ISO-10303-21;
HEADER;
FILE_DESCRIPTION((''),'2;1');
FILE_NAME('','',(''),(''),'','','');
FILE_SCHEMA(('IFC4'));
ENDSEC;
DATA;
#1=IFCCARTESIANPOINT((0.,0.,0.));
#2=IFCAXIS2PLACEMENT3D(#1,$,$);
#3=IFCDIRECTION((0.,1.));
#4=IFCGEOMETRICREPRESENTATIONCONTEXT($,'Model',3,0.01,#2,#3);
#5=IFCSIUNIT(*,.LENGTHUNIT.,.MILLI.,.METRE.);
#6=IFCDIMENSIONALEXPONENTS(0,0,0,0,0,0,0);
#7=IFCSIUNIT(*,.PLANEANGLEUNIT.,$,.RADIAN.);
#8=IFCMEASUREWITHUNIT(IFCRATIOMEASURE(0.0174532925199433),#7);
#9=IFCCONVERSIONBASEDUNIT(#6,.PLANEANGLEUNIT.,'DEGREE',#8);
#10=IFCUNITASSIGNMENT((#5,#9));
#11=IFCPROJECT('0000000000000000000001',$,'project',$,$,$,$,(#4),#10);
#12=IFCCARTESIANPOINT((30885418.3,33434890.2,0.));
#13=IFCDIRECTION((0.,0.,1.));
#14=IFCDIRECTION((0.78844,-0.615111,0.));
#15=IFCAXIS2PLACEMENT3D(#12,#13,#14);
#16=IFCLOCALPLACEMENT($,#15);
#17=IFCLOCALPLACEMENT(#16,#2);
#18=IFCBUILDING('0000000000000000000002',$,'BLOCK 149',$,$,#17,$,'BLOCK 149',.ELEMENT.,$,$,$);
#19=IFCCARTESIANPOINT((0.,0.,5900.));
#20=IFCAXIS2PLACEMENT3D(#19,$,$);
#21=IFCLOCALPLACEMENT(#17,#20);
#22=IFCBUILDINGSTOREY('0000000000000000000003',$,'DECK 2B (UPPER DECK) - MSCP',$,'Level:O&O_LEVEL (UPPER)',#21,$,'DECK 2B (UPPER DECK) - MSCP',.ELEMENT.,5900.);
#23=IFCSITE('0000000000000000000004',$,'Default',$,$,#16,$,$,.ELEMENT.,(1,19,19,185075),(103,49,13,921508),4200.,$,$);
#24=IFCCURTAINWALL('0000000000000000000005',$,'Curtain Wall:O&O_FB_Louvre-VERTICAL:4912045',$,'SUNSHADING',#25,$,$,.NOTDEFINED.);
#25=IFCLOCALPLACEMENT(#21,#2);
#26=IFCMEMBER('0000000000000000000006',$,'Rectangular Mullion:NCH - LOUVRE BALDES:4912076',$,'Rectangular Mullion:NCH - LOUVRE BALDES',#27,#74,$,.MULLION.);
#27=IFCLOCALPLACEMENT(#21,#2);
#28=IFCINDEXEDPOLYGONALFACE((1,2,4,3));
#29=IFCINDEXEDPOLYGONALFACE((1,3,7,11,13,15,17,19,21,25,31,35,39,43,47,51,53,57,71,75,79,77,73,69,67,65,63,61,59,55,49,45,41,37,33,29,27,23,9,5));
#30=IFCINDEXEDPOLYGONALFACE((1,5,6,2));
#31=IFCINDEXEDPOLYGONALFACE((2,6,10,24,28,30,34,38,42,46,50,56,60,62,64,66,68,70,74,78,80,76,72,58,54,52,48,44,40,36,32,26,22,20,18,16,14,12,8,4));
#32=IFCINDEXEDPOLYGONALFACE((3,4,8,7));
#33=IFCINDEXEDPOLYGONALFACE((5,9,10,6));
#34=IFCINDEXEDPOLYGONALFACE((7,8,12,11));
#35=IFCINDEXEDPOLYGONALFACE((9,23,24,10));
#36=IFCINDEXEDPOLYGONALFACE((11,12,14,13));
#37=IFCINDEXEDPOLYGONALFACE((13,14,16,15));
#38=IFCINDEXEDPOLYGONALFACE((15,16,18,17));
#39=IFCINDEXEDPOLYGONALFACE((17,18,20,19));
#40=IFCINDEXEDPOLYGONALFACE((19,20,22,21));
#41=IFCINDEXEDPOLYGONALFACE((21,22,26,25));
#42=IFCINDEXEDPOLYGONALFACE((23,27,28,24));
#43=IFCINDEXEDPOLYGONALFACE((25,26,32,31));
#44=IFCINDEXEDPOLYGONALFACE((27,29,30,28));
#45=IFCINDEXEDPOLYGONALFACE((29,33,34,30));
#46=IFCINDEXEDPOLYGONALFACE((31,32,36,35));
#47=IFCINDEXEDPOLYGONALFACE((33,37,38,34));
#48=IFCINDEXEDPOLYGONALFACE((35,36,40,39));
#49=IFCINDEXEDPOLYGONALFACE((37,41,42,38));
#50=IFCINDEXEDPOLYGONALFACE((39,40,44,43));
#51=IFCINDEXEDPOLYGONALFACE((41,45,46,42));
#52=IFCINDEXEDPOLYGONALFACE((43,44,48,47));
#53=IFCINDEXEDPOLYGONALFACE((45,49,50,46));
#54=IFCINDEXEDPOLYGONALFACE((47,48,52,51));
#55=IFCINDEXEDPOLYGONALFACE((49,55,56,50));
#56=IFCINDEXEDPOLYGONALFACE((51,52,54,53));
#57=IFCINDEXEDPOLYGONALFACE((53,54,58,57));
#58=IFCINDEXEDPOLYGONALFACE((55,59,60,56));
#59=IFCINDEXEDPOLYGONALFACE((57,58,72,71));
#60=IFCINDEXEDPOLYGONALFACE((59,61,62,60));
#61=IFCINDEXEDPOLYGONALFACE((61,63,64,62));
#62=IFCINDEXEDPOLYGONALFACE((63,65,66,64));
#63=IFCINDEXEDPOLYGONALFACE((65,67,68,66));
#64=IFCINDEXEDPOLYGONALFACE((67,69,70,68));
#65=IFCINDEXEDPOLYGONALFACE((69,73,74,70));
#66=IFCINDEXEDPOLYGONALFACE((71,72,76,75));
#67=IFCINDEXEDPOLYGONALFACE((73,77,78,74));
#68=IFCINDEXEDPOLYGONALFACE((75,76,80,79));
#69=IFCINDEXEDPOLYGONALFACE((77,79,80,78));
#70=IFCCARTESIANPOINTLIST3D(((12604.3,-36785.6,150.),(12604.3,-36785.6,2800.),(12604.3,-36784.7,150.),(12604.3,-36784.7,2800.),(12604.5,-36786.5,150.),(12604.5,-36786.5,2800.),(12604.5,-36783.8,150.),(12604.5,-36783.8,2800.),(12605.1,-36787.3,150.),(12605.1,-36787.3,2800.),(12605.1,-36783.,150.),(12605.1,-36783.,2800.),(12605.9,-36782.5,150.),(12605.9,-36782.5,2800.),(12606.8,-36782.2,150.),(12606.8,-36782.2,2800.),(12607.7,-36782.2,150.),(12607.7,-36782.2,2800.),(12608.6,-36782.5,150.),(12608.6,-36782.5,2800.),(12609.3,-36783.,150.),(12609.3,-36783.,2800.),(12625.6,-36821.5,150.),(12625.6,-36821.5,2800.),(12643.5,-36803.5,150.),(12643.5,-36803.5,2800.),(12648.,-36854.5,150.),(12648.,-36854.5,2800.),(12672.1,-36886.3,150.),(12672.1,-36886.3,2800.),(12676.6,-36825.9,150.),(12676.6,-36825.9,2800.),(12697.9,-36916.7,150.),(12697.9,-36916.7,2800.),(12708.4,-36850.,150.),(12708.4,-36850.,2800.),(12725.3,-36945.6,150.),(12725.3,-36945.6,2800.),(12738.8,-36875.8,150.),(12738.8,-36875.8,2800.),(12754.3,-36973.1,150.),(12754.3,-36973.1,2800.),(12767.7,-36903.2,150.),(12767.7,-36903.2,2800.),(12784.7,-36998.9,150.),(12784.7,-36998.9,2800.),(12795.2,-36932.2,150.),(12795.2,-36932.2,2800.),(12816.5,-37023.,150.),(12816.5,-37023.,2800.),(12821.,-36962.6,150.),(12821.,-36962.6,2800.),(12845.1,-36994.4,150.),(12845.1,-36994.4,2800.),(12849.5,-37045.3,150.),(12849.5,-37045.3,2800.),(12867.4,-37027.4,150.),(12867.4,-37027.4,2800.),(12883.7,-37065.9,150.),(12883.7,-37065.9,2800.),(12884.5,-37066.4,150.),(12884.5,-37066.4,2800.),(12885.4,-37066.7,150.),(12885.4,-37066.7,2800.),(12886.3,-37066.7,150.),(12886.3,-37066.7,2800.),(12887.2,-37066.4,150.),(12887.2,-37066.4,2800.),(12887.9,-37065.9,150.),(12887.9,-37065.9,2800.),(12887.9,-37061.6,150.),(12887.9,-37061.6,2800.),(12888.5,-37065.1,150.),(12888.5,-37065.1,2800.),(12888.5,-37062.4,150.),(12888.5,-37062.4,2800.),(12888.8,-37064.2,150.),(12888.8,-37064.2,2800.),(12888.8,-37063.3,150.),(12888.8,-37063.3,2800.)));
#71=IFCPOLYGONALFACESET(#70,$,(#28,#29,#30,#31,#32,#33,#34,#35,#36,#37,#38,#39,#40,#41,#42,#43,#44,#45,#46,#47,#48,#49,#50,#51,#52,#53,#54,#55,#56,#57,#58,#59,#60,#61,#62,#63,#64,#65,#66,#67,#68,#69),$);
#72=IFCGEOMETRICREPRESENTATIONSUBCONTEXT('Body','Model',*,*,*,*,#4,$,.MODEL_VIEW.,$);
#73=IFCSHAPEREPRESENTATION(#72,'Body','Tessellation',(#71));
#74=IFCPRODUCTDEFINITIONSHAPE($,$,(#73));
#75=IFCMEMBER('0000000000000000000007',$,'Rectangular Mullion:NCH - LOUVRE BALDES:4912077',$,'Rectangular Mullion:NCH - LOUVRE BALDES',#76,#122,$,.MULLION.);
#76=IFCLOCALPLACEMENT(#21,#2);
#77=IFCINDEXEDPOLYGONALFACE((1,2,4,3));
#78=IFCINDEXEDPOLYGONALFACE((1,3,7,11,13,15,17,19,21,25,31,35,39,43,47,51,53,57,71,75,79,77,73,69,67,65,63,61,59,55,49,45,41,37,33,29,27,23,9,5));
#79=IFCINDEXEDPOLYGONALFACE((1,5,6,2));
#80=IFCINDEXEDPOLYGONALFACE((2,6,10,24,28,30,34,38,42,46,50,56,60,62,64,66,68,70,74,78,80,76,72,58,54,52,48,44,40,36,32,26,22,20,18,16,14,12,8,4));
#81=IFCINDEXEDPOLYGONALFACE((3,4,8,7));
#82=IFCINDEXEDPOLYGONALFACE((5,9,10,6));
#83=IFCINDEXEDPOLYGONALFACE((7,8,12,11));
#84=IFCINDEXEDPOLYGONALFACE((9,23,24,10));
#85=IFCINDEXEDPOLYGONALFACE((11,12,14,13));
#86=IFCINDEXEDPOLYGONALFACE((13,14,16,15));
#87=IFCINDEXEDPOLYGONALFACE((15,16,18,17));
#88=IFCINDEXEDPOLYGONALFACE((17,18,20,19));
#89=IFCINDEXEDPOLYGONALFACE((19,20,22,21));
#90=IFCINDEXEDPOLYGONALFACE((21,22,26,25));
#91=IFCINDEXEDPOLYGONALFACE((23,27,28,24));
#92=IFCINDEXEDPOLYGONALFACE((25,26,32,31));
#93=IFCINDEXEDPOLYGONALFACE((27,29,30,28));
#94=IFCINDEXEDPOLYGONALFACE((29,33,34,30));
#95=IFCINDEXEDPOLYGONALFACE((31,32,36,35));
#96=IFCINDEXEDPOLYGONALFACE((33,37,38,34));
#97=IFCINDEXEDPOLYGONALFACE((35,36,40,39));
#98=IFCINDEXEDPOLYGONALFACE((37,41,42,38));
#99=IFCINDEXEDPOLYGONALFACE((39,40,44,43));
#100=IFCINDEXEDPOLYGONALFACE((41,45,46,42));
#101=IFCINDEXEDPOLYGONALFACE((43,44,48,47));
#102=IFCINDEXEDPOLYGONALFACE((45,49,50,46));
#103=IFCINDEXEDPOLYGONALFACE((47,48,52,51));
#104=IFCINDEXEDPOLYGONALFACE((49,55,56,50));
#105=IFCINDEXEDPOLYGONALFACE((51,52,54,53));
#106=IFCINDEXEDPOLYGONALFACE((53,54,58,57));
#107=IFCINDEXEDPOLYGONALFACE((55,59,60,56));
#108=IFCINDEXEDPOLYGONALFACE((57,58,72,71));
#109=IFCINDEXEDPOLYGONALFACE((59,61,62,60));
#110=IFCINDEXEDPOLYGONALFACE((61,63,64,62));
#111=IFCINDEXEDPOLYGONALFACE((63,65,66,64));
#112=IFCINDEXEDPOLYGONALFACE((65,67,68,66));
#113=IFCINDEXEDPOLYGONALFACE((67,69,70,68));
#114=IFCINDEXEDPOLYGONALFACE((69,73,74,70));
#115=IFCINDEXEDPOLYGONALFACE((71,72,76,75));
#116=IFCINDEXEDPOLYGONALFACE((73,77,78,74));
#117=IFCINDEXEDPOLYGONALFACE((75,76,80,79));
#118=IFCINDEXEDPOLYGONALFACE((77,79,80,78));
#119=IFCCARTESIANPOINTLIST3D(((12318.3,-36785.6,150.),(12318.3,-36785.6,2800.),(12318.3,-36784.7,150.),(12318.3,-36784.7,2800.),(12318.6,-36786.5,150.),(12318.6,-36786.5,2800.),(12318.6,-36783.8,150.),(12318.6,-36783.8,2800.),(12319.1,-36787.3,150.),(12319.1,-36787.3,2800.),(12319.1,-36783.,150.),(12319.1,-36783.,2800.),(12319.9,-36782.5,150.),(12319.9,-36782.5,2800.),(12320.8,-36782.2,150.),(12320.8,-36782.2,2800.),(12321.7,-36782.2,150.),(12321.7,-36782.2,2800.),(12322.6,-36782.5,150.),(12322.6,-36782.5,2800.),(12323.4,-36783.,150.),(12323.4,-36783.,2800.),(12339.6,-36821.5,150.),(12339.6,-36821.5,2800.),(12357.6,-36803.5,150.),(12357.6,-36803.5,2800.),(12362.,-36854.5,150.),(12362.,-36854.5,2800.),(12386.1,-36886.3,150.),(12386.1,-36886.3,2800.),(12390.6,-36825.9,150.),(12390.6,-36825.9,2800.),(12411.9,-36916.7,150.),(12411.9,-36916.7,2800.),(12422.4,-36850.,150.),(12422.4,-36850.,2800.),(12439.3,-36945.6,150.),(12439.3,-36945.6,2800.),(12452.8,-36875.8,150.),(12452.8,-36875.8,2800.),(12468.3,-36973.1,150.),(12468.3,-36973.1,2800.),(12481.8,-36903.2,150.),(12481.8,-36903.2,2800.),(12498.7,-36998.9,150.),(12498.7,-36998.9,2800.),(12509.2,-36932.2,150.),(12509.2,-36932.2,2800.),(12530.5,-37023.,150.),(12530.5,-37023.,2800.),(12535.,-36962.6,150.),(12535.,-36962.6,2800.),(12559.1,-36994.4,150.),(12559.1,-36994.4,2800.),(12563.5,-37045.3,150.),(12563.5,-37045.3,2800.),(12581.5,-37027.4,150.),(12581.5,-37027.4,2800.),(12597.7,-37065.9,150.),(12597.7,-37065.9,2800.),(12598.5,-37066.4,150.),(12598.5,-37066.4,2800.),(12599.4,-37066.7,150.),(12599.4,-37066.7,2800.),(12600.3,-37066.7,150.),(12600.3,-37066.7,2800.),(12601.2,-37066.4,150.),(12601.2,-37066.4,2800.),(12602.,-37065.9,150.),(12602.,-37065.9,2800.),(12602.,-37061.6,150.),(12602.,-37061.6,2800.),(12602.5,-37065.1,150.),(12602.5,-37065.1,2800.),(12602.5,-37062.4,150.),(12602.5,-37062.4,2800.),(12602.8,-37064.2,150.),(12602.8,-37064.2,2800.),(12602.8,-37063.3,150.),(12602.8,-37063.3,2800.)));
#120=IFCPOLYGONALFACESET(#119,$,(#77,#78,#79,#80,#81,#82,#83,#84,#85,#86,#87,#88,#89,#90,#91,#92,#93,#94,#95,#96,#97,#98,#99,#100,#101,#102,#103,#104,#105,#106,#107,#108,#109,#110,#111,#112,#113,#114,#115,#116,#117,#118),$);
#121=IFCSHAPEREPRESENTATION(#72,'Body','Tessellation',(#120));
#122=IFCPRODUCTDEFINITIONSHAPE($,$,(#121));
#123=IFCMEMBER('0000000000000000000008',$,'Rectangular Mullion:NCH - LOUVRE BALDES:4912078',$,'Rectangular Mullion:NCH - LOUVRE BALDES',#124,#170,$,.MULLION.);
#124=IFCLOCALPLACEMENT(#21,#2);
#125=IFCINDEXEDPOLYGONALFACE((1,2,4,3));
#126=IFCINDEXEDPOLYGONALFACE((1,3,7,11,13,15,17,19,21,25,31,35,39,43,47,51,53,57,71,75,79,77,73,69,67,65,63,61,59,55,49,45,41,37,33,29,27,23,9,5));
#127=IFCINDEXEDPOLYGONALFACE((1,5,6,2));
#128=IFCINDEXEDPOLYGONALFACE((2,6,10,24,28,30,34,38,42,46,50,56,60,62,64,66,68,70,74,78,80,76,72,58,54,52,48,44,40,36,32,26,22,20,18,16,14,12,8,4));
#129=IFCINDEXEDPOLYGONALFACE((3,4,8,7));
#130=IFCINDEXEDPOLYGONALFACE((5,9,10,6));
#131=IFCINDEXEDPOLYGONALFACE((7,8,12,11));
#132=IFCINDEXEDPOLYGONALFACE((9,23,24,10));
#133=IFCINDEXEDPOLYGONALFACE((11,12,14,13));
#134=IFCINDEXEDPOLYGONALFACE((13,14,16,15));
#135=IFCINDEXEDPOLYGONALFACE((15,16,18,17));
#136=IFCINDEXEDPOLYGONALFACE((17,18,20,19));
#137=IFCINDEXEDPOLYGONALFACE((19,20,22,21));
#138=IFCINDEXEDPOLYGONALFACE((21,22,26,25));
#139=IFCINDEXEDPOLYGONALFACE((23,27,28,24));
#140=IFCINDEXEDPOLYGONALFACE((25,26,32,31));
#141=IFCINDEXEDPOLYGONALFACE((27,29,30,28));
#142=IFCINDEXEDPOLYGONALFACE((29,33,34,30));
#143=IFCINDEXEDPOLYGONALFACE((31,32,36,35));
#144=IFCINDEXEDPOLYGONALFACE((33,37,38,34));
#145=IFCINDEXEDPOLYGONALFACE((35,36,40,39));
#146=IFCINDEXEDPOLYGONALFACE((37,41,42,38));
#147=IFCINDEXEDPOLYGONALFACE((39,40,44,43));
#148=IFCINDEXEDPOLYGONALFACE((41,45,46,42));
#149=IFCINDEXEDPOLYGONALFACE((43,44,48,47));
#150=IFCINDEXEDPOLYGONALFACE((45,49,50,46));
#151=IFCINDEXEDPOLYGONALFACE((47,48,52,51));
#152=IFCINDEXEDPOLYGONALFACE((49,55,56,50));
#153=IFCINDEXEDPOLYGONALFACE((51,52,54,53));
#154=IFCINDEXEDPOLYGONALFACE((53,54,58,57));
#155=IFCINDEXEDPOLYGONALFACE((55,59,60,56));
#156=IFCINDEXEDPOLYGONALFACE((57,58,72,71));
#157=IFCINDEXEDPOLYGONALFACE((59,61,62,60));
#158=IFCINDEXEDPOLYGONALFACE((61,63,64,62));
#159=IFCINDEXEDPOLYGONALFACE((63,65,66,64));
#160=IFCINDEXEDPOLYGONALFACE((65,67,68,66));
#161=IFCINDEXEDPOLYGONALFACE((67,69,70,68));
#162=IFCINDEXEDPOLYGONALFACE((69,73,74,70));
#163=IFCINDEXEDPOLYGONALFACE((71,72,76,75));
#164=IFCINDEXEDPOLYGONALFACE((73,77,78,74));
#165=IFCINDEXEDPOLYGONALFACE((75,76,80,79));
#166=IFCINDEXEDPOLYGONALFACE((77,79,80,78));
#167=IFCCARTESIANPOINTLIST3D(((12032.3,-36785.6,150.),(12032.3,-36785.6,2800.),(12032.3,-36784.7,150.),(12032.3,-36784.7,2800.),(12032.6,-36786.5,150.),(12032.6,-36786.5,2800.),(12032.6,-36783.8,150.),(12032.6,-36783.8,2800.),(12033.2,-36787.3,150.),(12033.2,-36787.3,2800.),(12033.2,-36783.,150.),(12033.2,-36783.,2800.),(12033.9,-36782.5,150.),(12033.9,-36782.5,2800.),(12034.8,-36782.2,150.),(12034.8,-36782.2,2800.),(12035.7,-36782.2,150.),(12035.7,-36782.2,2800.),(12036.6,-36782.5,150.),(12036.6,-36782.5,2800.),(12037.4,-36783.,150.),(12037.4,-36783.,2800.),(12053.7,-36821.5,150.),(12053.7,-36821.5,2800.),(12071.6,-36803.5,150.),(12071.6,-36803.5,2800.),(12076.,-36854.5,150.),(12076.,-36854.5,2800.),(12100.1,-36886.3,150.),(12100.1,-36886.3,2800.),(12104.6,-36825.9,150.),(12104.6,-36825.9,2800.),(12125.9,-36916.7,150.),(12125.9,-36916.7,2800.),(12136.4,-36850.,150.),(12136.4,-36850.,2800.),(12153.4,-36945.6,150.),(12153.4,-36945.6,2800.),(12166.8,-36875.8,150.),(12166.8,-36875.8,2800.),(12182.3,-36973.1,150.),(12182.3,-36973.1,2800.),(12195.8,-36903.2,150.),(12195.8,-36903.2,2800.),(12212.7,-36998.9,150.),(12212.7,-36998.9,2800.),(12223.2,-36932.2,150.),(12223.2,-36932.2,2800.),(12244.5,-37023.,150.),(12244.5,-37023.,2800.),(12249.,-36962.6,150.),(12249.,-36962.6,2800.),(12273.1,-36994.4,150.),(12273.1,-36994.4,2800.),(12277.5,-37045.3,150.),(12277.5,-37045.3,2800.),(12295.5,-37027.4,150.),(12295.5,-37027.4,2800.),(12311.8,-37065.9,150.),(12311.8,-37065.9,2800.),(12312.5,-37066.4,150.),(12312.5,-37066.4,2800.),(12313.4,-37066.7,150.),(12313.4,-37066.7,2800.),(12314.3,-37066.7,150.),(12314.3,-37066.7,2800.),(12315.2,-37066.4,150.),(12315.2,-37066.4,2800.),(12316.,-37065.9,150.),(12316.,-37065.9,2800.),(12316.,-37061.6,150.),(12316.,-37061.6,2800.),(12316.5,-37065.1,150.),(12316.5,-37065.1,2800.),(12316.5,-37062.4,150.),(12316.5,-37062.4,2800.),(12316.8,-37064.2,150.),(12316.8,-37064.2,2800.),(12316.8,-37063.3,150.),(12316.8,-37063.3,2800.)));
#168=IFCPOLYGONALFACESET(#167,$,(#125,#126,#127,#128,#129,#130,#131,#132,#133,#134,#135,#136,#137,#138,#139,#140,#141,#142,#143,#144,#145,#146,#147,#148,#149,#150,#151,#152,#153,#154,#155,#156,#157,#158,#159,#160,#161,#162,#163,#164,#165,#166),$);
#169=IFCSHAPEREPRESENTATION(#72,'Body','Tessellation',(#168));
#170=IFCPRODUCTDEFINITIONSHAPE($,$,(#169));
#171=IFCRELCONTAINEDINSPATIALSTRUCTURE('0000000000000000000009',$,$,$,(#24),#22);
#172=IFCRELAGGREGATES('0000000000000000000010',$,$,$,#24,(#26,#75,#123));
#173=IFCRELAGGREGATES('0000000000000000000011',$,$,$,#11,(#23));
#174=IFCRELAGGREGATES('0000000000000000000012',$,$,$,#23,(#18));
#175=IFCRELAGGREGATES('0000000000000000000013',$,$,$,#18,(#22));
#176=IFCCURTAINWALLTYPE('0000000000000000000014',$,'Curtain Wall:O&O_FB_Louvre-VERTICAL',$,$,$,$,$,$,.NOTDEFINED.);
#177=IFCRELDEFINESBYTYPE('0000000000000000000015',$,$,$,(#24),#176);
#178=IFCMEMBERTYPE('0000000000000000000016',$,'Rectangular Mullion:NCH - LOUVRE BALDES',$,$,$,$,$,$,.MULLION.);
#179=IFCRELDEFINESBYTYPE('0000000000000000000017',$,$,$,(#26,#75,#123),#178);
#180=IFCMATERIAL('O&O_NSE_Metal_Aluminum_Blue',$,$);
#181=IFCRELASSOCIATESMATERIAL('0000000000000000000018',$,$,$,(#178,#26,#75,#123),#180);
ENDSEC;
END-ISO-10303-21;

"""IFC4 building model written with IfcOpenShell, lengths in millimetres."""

from ifc_helpers import new_model, entity, si_unit, converted_unit, direction, frame, origin, place, context, subcontext, project, spatial, indexed_curve, outline, extrude, source, transform, mapped, material, type_object, type_shapes, element, aggregate, save


model = new_model("IFC4")

# Units and contexts
model_context = context("Model", 3, precision=0.01, world=origin(), true_north=direction((0.0, 1.0)))
body_context = subcontext(model_context, "Body", "Model", "MODEL_VIEW")
ifc_project = project(units=[si_unit("LENGTHUNIT", "METRE", prefix="MILLI"), converted_unit("PLANEANGLEUNIT", "DEGREE", entity("IfcRatioMeasure", 0.0174532925199433), si_unit("PLANEANGLEUNIT", "RADIAN"), dimensions=[0, 0, 0, 0, 0, 0, 0])], contexts=[model_context])

# Site, building, storey
site_placement = place(None, frame((30885418.3, 33434890.2, 0.0), z_axis=(0.0, 0.0, 1.0), x_axis=(0.78844, -0.615111, 0.0)))
site = spatial("IfcSite", under=ifc_project, at=site_placement, Name="Default", CompositionType="ELEMENT", RefLatitude=(1, 19, 19, 185075), RefLongitude=(103, 49, 13, 921508), RefElevation=4200.0)
building_placement = place(site_placement, origin())
building = spatial("IfcBuilding", under=site, at=building_placement, Name="BLOCK 149", LongName="BLOCK 149", CompositionType="ELEMENT")
storey_placement = place(building_placement, frame((0.0, 0.0, 5900.0)))
storey = spatial("IfcBuildingStorey", under=building, at=storey_placement, Name="DECK 2B (UPPER DECK) - MSCP", ObjectType="Level:O&O_LEVEL (UPPER)", LongName="DECK 2B (UPPER DECK) - MSCP", CompositionType="ELEMENT", Elevation=5900.0)

# Curtain wall, members
curtain_wall_type = type_object("IfcCurtainWallType", Name="Curtain Wall:O&O_FB_Louvre-VERTICAL", PredefinedType="NOTDEFINED")
curtain_wall_placement = place(storey_placement, frame((0.0, 0.0, -5900.0)))
curtain_wall = element("IfcCurtainWall", 1, at=curtain_wall_placement, inside=storey, type_object=curtain_wall_type, Name="Curtain Wall:O&O_FB_Louvre-VERTICAL:4912045", ObjectType="SUNSHADING", PredefinedType="NOTDEFINED")
placement = place(building_placement, origin())
ifc_material_1 = material(Name="O&O_NSE_Metal_Aluminum_Blue")
member_type_1 = type_object("IfcMemberType", Name="Rectangular Mullion:NCH - LOUVRE BALDES", PredefinedType="MULLION", material=ifc_material_1)
shared_shape_1 = source(origin(), body_context, "Body", "SweptSolid", [
    extrude(outline(indexed_curve([(55.9, -188.9), (54.8, -149.1), (51.6, -109.3), (46.1, -69.8), (38.6, -30.6), (28.9, 8.1), (17.1, 46.2), (3.3, 83.6), (-12.6, 120.2), (-30.4, 155.9), (-50.1, 190.5), (-50.5, 191.4), (-51.1, 192.1), (-52.0, 192.5), (-52.9, 192.7), (-53.8, 192.6), (-54.7, 192.2), (-55.4, 191.6), (-55.8, 190.8), (-56.0, 189.9), (-55.9, 188.9), (-54.8, 149.1), (-51.6, 109.3), (-46.1, 69.8), (-38.6, 30.6), (-28.9, -8.1), (-17.1, -46.2), (-3.3, -83.6), (12.6, -120.2), (30.4, -155.9), (50.1, -190.5), (50.5, -191.4), (51.1, -192.1), (52.0, -192.5), (52.9, -192.7), (53.8, -192.6), (54.7, -192.2), (55.4, -191.6), (55.8, -190.8), (56.0, -189.9), (55.9, -188.9)], self_intersect=False)), frame((0.0, 0.0, -2650.0), z_axis=(0.0, 0.0, 1.0), x_axis=(0.490779, -0.871284, 0.0)), (0.0, 0.0, 1.0), 2650.0),
])
type_shapes(member_type_1, [shared_shape_1])
member_1_placement = place(placement, frame((12746.5, -36924.4, 6050.0), z_axis=(0.0, 0.0, -1.0), x_axis=(-1.0, 0.0, 0.0)))
member_1 = element("IfcMember", 2, at=member_1_placement, type_object=member_type_1, material=ifc_material_1, Name="Rectangular Mullion:NCH - LOUVRE BALDES:4912076", ObjectType="Rectangular Mullion:NCH - LOUVRE BALDES", PredefinedType="MULLION", context=body_context, shape_type="MappedRepresentation", body=[
    mapped(shared_shape_1, transform((0.0, 0.0, 0.0), scale=1.0)),
])
member_2_placement = place(placement, frame((12460.5, -36924.4, 6050.0), z_axis=(0.0, 0.0, -1.0), x_axis=(-1.0, 0.0, 0.0)))
member_2 = element("IfcMember", 3, at=member_2_placement, type_object=member_type_1, material=ifc_material_1, Name="Rectangular Mullion:NCH - LOUVRE BALDES:4912077", ObjectType="Rectangular Mullion:NCH - LOUVRE BALDES", PredefinedType="MULLION", context=body_context, shape_type="MappedRepresentation", body=[
    mapped(shared_shape_1, transform((0.0, 0.0, 0.0), scale=1.0)),
])
member_3_placement = place(placement, frame((12174.6, -36924.4, 6050.0), z_axis=(0.0, 0.0, -1.0), x_axis=(-1.0, 0.0, 0.0)))
member_3 = element("IfcMember", 4, at=member_3_placement, type_object=member_type_1, material=ifc_material_1, Name="Rectangular Mullion:NCH - LOUVRE BALDES:4912078", ObjectType="Rectangular Mullion:NCH - LOUVRE BALDES", PredefinedType="MULLION", context=body_context, shape_type="MappedRepresentation", body=[
    mapped(shared_shape_1, transform((0.0, 0.0, 0.0), scale=1.0)),
])
aggregate(curtain_wall, [member_1, member_2, member_3])

save(model, "model.ifc")
